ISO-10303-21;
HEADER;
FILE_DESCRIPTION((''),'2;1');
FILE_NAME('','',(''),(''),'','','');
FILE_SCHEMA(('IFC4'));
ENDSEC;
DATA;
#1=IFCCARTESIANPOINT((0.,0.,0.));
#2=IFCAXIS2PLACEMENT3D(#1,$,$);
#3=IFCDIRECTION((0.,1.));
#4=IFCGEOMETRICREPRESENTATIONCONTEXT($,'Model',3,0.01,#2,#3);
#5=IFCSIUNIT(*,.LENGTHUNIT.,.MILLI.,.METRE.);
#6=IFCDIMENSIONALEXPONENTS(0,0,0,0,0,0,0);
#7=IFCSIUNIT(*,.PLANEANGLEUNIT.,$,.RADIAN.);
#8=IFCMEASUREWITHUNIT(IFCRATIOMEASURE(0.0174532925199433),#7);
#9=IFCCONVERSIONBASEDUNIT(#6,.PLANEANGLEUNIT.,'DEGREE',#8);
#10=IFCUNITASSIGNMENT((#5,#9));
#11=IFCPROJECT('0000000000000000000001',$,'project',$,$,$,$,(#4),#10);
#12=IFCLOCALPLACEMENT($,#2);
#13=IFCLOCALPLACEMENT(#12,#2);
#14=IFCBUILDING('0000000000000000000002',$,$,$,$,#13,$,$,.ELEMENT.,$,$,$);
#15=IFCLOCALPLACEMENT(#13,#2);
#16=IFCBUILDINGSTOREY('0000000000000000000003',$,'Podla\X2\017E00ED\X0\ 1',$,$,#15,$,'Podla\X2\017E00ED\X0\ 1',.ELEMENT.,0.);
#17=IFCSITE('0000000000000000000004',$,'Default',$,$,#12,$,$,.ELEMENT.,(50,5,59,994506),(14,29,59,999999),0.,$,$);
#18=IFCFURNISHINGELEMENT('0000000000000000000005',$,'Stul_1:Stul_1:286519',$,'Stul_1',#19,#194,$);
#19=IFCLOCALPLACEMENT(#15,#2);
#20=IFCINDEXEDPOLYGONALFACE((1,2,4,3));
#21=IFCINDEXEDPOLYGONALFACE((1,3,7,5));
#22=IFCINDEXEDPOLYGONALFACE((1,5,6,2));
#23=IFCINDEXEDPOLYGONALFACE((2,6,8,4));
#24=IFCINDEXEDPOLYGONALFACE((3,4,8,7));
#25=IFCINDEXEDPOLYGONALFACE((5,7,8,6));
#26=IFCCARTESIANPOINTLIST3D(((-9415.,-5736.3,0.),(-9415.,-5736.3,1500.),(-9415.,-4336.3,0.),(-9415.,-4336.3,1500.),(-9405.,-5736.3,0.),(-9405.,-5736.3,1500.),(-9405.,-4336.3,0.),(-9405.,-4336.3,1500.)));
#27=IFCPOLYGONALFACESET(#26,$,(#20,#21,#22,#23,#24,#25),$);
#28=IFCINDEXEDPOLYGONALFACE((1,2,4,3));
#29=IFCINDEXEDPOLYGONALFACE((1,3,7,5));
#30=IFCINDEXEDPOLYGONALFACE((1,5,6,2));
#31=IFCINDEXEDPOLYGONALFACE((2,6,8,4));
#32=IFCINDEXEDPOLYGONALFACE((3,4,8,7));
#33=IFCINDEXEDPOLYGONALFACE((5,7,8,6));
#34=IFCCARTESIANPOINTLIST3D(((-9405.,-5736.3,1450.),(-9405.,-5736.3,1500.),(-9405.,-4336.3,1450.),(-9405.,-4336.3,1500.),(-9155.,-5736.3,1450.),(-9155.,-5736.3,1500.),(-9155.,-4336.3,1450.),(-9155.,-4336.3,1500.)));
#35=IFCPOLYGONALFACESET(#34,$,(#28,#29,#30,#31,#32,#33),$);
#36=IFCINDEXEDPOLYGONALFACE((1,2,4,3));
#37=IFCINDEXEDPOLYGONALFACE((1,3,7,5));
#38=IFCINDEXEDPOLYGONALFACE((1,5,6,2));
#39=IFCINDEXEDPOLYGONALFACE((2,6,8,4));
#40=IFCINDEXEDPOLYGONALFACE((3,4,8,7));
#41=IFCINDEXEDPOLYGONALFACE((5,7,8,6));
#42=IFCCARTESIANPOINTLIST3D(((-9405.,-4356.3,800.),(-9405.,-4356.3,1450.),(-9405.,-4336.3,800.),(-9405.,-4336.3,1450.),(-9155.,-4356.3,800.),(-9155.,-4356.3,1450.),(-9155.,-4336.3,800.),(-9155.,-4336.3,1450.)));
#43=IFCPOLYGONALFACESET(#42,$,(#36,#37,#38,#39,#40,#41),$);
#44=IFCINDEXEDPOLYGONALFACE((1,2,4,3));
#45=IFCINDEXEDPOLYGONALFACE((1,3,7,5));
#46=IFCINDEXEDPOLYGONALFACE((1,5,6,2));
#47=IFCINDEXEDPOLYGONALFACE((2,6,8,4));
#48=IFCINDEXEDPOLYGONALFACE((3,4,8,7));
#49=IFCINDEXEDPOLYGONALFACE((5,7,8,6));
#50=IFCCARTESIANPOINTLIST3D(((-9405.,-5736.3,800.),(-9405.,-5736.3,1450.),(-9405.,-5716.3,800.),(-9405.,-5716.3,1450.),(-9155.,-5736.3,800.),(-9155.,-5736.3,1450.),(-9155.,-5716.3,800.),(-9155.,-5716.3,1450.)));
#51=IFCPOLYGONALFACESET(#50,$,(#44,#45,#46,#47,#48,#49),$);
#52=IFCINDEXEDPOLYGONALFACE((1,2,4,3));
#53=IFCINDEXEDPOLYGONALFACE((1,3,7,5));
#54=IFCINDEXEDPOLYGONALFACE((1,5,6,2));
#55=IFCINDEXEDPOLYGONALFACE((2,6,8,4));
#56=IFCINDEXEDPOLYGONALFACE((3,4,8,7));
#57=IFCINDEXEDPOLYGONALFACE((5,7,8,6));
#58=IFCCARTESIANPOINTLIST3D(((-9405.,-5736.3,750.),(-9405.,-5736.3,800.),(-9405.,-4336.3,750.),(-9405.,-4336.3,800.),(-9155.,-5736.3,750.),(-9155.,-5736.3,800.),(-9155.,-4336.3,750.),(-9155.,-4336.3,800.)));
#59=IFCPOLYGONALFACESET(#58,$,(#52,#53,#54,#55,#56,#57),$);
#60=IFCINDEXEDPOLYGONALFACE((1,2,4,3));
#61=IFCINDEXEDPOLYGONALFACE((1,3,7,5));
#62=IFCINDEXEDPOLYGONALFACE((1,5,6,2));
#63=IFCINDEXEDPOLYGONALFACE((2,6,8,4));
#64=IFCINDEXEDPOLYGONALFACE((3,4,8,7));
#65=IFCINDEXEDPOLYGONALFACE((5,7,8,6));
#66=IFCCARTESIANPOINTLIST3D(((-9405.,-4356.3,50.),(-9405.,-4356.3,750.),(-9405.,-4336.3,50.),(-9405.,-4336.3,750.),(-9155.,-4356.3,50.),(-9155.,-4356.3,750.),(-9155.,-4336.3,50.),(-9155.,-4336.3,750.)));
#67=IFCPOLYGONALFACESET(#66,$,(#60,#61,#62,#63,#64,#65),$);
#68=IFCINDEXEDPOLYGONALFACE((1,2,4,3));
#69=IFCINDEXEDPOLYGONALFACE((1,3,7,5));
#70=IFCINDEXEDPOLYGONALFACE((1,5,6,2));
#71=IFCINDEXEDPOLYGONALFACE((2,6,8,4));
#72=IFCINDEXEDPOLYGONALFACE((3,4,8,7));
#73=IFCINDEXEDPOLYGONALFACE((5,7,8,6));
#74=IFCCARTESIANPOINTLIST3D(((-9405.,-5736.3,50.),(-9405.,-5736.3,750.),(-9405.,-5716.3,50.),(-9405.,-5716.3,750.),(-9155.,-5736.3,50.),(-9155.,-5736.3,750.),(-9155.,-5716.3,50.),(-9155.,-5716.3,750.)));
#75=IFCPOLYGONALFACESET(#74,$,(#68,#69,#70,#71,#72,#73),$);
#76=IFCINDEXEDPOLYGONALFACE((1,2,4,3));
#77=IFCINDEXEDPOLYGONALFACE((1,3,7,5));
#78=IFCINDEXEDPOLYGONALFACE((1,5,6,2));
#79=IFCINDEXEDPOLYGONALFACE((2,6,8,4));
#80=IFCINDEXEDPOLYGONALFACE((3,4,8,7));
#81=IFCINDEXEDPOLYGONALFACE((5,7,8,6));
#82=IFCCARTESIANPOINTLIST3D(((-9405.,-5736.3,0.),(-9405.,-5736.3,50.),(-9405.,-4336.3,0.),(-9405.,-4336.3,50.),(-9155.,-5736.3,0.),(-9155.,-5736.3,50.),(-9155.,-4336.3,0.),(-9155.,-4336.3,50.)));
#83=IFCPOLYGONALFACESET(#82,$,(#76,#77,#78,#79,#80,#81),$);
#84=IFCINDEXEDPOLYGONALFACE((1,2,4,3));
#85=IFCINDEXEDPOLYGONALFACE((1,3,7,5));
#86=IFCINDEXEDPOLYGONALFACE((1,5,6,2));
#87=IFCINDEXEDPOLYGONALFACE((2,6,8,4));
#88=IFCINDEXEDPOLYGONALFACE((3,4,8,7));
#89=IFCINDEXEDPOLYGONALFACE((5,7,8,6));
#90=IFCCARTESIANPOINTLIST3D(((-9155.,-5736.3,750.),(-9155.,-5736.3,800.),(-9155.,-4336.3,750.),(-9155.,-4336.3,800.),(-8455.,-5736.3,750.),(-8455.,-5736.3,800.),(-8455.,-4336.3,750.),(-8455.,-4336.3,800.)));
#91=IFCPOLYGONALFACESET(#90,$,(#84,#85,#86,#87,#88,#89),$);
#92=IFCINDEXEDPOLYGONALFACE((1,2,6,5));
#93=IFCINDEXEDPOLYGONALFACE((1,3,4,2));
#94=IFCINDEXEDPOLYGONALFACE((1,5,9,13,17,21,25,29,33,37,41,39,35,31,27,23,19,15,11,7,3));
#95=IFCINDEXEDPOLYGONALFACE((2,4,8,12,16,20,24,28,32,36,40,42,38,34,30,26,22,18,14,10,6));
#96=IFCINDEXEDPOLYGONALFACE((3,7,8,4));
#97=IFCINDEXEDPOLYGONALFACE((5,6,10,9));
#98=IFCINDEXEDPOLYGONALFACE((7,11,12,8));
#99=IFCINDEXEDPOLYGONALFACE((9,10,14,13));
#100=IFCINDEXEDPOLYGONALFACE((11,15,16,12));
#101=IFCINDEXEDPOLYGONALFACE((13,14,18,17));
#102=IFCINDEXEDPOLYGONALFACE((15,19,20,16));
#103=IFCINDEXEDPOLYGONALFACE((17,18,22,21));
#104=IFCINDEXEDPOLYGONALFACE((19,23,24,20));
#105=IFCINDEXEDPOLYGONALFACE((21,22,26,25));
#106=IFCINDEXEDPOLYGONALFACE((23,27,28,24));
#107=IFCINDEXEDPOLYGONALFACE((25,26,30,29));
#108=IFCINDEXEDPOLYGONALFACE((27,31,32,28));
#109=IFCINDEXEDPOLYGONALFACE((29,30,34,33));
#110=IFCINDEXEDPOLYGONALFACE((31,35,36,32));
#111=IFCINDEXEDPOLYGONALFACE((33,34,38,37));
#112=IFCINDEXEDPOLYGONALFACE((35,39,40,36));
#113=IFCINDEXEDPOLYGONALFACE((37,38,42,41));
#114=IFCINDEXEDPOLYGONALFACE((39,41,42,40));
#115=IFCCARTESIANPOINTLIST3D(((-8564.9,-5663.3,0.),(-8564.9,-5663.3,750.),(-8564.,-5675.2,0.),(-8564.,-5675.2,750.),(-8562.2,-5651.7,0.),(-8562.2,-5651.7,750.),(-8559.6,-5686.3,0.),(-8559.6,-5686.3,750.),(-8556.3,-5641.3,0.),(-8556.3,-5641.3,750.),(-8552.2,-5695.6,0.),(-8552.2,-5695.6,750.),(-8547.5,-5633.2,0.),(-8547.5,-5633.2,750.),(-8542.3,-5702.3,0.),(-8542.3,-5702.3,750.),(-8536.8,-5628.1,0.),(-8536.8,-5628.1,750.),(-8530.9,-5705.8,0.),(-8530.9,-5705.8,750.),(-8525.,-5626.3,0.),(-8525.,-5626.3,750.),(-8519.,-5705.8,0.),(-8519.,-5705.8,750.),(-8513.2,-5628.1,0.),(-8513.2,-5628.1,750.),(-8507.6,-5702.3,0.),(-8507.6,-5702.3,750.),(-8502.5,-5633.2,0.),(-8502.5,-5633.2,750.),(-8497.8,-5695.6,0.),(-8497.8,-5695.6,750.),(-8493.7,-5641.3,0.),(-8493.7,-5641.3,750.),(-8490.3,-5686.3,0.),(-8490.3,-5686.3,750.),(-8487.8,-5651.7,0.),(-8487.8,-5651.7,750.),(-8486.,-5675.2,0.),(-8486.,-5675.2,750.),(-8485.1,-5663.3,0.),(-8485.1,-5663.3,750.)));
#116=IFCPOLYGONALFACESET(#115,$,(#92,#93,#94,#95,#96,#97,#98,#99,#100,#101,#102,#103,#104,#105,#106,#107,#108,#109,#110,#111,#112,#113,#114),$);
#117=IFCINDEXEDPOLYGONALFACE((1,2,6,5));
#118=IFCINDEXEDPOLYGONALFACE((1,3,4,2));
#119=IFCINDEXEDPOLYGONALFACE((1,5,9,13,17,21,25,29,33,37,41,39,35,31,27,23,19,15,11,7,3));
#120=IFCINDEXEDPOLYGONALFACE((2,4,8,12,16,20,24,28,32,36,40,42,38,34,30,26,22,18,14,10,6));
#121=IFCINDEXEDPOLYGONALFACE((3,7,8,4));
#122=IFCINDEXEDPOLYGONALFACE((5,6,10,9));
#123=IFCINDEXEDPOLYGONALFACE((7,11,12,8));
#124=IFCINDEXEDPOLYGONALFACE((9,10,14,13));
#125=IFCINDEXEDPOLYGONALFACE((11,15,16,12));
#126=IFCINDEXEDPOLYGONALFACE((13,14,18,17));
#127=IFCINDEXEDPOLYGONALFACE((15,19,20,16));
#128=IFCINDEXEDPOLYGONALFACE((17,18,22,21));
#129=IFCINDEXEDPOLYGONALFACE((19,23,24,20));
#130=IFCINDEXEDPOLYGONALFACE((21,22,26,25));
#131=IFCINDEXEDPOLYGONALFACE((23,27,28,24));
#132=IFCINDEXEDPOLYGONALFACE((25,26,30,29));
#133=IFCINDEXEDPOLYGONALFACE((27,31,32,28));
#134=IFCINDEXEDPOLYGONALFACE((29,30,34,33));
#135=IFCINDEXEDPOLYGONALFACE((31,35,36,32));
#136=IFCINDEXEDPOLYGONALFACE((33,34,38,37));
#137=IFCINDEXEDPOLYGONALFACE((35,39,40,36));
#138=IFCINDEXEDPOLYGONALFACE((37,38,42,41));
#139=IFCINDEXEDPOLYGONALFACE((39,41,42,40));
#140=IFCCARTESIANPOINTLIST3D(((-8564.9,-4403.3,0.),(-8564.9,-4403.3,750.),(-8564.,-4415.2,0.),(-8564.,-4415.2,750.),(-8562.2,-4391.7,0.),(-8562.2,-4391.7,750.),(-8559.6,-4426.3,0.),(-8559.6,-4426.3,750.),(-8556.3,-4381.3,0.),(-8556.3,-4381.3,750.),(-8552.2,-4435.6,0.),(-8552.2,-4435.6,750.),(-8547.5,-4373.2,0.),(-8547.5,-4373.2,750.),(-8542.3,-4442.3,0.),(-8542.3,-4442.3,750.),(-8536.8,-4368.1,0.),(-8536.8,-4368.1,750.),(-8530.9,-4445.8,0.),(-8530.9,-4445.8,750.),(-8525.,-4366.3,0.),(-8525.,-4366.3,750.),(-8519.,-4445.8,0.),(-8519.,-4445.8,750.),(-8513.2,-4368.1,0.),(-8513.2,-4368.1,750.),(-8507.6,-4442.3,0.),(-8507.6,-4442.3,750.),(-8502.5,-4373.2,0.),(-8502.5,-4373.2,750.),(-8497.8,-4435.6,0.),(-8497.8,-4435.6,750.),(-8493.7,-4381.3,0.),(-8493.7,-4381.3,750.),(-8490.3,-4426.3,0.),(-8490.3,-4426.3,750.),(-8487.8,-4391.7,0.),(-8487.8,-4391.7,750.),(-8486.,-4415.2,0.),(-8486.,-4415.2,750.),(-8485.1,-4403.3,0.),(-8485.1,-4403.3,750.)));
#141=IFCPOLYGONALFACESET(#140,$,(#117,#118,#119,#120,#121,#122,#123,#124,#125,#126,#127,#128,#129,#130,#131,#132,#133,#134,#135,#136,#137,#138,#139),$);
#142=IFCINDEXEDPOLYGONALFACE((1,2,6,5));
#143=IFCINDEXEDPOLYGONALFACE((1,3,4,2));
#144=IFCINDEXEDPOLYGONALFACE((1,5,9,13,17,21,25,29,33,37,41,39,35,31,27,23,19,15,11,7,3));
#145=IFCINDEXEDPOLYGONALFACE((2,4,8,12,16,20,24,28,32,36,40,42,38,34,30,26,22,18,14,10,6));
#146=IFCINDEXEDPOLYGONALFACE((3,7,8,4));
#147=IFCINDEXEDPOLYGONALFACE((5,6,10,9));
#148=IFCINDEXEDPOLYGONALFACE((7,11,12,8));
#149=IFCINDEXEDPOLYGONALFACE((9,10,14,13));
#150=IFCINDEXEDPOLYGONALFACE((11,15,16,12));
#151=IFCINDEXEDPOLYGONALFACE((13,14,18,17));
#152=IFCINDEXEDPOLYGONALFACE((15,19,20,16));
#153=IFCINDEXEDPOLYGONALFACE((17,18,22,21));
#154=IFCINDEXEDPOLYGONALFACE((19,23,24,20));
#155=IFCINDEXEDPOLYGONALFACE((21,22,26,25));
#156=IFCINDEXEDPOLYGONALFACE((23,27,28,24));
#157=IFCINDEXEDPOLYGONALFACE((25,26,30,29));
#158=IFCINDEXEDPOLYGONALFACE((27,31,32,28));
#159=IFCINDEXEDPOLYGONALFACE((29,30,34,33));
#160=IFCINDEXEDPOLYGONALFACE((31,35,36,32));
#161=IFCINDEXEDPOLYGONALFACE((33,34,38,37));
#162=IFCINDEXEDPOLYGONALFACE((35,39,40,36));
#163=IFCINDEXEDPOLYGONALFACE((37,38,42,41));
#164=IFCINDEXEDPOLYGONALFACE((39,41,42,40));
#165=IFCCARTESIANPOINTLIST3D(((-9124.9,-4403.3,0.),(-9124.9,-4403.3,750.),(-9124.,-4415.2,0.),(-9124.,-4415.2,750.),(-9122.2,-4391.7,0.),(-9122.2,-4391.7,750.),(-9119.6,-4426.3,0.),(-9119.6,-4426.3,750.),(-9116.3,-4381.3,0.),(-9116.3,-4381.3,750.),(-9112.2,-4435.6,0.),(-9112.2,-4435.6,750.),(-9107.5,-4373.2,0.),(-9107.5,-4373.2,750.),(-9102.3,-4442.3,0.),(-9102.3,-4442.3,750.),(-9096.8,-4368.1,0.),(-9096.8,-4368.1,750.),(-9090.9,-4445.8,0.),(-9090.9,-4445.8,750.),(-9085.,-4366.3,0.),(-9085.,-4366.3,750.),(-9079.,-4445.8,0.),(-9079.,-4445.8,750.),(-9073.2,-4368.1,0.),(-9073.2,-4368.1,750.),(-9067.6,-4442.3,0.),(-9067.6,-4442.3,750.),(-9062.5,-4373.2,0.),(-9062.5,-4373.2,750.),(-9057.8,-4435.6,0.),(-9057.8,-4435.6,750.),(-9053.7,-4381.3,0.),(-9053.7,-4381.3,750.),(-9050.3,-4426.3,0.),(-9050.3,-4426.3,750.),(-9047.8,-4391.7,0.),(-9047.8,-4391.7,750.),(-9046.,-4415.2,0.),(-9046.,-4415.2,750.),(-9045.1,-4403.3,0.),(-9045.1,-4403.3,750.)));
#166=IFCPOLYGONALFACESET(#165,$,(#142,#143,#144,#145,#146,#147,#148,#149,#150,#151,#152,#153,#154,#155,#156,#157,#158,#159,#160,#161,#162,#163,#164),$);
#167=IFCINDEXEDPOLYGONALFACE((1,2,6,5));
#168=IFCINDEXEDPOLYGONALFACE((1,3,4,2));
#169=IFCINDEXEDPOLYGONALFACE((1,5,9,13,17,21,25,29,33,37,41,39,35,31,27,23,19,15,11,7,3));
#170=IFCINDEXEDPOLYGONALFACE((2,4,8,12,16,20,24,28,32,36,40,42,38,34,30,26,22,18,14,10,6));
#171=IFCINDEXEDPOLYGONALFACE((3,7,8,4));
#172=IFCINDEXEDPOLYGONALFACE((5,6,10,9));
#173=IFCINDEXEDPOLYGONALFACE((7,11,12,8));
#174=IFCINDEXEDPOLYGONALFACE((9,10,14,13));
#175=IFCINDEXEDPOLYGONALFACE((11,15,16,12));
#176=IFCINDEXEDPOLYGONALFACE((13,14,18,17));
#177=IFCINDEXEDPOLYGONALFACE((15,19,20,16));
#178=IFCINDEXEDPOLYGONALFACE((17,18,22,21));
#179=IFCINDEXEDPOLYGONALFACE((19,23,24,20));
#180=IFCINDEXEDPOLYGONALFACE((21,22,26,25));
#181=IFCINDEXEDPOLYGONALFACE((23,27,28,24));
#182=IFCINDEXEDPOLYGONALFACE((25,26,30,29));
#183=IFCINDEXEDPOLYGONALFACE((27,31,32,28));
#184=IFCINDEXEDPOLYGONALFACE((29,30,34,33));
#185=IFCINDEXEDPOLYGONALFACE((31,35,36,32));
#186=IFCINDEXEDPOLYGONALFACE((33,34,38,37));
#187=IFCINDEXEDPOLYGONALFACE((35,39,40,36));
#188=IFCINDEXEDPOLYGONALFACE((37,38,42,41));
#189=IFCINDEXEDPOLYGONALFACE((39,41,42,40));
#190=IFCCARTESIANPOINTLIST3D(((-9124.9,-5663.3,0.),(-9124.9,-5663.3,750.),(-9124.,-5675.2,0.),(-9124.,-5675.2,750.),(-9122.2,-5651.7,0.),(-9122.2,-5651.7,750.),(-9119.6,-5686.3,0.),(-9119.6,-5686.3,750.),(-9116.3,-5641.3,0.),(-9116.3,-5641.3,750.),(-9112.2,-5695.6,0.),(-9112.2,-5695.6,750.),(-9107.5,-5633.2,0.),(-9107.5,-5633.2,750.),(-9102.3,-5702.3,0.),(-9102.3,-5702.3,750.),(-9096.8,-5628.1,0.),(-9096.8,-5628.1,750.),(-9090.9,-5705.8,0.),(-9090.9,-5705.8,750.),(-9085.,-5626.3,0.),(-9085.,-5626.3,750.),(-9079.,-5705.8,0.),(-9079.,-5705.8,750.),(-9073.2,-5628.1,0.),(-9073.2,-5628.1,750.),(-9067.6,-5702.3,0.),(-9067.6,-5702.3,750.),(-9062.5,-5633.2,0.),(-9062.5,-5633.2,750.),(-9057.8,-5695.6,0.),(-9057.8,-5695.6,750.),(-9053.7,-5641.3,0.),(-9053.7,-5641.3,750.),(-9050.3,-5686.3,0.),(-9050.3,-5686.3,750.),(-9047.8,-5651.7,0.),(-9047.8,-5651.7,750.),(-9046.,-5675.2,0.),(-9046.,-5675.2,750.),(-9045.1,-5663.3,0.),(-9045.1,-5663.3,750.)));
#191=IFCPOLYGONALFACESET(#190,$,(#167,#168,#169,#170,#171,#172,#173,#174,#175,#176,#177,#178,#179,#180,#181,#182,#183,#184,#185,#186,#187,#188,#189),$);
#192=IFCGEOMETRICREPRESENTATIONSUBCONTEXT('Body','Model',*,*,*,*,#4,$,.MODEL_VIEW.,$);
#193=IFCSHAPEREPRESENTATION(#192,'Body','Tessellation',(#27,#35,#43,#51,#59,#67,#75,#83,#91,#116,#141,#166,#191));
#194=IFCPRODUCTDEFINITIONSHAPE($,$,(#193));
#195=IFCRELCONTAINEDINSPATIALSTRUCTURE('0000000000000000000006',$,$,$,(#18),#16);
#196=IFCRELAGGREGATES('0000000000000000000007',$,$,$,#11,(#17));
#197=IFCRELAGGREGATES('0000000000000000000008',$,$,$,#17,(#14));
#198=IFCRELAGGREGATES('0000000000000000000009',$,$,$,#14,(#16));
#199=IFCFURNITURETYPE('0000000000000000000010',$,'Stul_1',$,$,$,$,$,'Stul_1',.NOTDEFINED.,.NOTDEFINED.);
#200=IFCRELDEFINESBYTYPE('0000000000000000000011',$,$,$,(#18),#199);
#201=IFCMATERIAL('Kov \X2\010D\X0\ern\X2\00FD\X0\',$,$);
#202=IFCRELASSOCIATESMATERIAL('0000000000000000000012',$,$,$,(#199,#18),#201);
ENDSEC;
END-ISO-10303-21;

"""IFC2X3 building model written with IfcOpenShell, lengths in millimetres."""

from ifc_helpers import new_model, entity, si_unit, converted_unit, direction, frame, frame_2d, origin, origin_2d_with_axis, place, context, subcontext, project, spatial, rectangle, circle, extrude, source, transform, mapped, material, type_object, type_shapes, element, save


model = new_model("IFC2X3")

# Units and contexts
model_context = context("Model", 3, precision=0.01, world=origin(), true_north=direction((0.0, 1.0)))
body_context = subcontext(model_context, "Body", "Model", "MODEL_VIEW")
ifc_project = project(units=[si_unit("LENGTHUNIT", "METRE", prefix="MILLI"), converted_unit("PLANEANGLEUNIT", "DEGREE", entity("IfcRatioMeasure", 0.0174532925199433), si_unit("PLANEANGLEUNIT", "RADIAN"), dimensions=[0, 0, 0, 0, 0, 0, 0])], contexts=[model_context])

# Site, building, storey
site_placement = place(None, origin())
site = spatial("IfcSite", under=ifc_project, at=site_placement, Name="Default", CompositionType="ELEMENT", RefLatitude=(50, 5, 59, 994506), RefLongitude=(14, 29, 59, 999999), RefElevation=0.0)
building_placement = place(site_placement, origin())
building = spatial("IfcBuilding", under=site, at=building_placement, CompositionType="ELEMENT")
storey_placement = place(building_placement, origin())
storey = spatial("IfcBuildingStorey", under=building, at=storey_placement, Name="Podlaží 1", LongName="Podlaží 1", CompositionType="ELEMENT", Elevation=0.0)

# Furnishing element
ifc_material_1 = material(Name="Kov černý")
furniture_type = type_object("IfcFurnitureType", Name="Stul_1", ElementType="Stul_1", material=ifc_material_1)
shared_shape_1 = source(origin(), body_context, "Body", "SweptSolid", [
    extrude(rectangle(XDim=1400.0, YDim=10.0, at=origin_2d_with_axis()), frame((0.0, 605.0, 0.0), z_axis=(0.0, 0.0, 1.0), x_axis=(-1.0, 0.0, 0.0)), (0.0, 0.0, 1.0), 1500.0),
    extrude(rectangle(XDim=1400.0, YDim=250.0, at=frame_2d((0.0, 0.0), x_axis=(1.0, 0.0))), frame((0.0, 475.0, 1450.0), z_axis=(0.0, 0.0, 1.0), x_axis=(-1.0, 0.0, 0.0)), (0.0, 0.0, 1.0), 50.0),
    extrude(rectangle(XDim=20.0, YDim=250.0, at=origin_2d_with_axis()), frame((690.0, 475.0, 800.0), z_axis=(0.0, 0.0, 1.0), x_axis=(-1.0, 0.0, 0.0)), (0.0, 0.0, 1.0), 650.0),
    extrude(rectangle(XDim=20.0, YDim=250.0, at=frame_2d((0.0, 0.0), x_axis=(1.0, 0.0))), frame((-690.0, 475.0, 800.0), z_axis=(0.0, 0.0, 1.0), x_axis=(-1.0, 0.0, 0.0)), (0.0, 0.0, 1.0), 650.0),
    extrude(rectangle(XDim=1400.0, YDim=250.0, at=origin_2d_with_axis()), frame((0.0, 475.0, 750.0), z_axis=(0.0, 0.0, 1.0), x_axis=(-1.0, 0.0, 0.0)), (0.0, 0.0, 1.0), 50.0),
    extrude(rectangle(XDim=20.0, YDim=250.0, at=origin_2d_with_axis()), frame((690.0, 475.0, 50.0), z_axis=(0.0, 0.0, 1.0), x_axis=(-1.0, 0.0, 0.0)), (0.0, 0.0, 1.0), 700.0),
    extrude(rectangle(XDim=20.0, YDim=250.0, at=frame_2d((0.0, 0.0), x_axis=(1.0, 0.0))), frame((-690.0, 475.0, 50.0), z_axis=(0.0, 0.0, 1.0), x_axis=(-1.0, 0.0, 0.0)), (0.0, 0.0, 1.0), 700.0),
    extrude(rectangle(XDim=1400.0, YDim=250.0, at=origin_2d_with_axis()), frame((0.0, 475.0, 0.0), z_axis=(0.0, 0.0, 1.0), x_axis=(-1.0, 0.0, 0.0)), (0.0, 0.0, 1.0), 50.0),
    extrude(rectangle(XDim=1400.0, YDim=700.0, at=origin_2d_with_axis()), frame((0.0, 0.0, 750.0), z_axis=(0.0, 0.0, 1.0), x_axis=(-1.0, 0.0, 0.0)), (0.0, 0.0, 1.0), 50.0),
    extrude(circle(Radius=40.0, at=frame_2d((0.0, 0.0), x_axis=(1.0, 0.0))), frame((-630.0, -280.0, 0.0)), (0.0, 0.0, 1.0), 750.0),
    extrude(circle(Radius=40.0, at=frame_2d((0.0, 0.0), x_axis=(1.0, 0.0))), frame((630.0, -280.0, 0.0)), (0.0, 0.0, 1.0), 750.0),
    extrude(circle(Radius=40.0, at=frame_2d((0.0, 0.0), x_axis=(1.0, 0.0))), frame((630.0, 280.0, 0.0)), (0.0, 0.0, 1.0), 750.0),
    extrude(circle(Radius=40.0, at=frame_2d((0.0, 0.0), x_axis=(1.0, 0.0))), frame((-630.0, 280.0, 0.0)), (0.0, 0.0, 1.0), 750.0),
])
type_shapes(furniture_type, [shared_shape_1])
for number, where, z_axis, x_axis, name in (
    (1, (-8805.0, -5036.3, 0.0), (0.0, 0.0, 1.0), (0.0, 1.0, 0.0), "Stul_1:Stul_1:286519"),
):
    element("IfcFurnishingElement", number, at=place(storey_placement, frame(where, z_axis=z_axis, x_axis=x_axis)), inside=storey, type_object=furniture_type, material=ifc_material_1, Name=name, ObjectType="Stul_1", context=body_context, shape_type="MappedRepresentation", body=[
        mapped(shared_shape_1, transform((0.0, 0.0, 0.0), scale=1.0)),
    ])

save(model, "model.ifc")
